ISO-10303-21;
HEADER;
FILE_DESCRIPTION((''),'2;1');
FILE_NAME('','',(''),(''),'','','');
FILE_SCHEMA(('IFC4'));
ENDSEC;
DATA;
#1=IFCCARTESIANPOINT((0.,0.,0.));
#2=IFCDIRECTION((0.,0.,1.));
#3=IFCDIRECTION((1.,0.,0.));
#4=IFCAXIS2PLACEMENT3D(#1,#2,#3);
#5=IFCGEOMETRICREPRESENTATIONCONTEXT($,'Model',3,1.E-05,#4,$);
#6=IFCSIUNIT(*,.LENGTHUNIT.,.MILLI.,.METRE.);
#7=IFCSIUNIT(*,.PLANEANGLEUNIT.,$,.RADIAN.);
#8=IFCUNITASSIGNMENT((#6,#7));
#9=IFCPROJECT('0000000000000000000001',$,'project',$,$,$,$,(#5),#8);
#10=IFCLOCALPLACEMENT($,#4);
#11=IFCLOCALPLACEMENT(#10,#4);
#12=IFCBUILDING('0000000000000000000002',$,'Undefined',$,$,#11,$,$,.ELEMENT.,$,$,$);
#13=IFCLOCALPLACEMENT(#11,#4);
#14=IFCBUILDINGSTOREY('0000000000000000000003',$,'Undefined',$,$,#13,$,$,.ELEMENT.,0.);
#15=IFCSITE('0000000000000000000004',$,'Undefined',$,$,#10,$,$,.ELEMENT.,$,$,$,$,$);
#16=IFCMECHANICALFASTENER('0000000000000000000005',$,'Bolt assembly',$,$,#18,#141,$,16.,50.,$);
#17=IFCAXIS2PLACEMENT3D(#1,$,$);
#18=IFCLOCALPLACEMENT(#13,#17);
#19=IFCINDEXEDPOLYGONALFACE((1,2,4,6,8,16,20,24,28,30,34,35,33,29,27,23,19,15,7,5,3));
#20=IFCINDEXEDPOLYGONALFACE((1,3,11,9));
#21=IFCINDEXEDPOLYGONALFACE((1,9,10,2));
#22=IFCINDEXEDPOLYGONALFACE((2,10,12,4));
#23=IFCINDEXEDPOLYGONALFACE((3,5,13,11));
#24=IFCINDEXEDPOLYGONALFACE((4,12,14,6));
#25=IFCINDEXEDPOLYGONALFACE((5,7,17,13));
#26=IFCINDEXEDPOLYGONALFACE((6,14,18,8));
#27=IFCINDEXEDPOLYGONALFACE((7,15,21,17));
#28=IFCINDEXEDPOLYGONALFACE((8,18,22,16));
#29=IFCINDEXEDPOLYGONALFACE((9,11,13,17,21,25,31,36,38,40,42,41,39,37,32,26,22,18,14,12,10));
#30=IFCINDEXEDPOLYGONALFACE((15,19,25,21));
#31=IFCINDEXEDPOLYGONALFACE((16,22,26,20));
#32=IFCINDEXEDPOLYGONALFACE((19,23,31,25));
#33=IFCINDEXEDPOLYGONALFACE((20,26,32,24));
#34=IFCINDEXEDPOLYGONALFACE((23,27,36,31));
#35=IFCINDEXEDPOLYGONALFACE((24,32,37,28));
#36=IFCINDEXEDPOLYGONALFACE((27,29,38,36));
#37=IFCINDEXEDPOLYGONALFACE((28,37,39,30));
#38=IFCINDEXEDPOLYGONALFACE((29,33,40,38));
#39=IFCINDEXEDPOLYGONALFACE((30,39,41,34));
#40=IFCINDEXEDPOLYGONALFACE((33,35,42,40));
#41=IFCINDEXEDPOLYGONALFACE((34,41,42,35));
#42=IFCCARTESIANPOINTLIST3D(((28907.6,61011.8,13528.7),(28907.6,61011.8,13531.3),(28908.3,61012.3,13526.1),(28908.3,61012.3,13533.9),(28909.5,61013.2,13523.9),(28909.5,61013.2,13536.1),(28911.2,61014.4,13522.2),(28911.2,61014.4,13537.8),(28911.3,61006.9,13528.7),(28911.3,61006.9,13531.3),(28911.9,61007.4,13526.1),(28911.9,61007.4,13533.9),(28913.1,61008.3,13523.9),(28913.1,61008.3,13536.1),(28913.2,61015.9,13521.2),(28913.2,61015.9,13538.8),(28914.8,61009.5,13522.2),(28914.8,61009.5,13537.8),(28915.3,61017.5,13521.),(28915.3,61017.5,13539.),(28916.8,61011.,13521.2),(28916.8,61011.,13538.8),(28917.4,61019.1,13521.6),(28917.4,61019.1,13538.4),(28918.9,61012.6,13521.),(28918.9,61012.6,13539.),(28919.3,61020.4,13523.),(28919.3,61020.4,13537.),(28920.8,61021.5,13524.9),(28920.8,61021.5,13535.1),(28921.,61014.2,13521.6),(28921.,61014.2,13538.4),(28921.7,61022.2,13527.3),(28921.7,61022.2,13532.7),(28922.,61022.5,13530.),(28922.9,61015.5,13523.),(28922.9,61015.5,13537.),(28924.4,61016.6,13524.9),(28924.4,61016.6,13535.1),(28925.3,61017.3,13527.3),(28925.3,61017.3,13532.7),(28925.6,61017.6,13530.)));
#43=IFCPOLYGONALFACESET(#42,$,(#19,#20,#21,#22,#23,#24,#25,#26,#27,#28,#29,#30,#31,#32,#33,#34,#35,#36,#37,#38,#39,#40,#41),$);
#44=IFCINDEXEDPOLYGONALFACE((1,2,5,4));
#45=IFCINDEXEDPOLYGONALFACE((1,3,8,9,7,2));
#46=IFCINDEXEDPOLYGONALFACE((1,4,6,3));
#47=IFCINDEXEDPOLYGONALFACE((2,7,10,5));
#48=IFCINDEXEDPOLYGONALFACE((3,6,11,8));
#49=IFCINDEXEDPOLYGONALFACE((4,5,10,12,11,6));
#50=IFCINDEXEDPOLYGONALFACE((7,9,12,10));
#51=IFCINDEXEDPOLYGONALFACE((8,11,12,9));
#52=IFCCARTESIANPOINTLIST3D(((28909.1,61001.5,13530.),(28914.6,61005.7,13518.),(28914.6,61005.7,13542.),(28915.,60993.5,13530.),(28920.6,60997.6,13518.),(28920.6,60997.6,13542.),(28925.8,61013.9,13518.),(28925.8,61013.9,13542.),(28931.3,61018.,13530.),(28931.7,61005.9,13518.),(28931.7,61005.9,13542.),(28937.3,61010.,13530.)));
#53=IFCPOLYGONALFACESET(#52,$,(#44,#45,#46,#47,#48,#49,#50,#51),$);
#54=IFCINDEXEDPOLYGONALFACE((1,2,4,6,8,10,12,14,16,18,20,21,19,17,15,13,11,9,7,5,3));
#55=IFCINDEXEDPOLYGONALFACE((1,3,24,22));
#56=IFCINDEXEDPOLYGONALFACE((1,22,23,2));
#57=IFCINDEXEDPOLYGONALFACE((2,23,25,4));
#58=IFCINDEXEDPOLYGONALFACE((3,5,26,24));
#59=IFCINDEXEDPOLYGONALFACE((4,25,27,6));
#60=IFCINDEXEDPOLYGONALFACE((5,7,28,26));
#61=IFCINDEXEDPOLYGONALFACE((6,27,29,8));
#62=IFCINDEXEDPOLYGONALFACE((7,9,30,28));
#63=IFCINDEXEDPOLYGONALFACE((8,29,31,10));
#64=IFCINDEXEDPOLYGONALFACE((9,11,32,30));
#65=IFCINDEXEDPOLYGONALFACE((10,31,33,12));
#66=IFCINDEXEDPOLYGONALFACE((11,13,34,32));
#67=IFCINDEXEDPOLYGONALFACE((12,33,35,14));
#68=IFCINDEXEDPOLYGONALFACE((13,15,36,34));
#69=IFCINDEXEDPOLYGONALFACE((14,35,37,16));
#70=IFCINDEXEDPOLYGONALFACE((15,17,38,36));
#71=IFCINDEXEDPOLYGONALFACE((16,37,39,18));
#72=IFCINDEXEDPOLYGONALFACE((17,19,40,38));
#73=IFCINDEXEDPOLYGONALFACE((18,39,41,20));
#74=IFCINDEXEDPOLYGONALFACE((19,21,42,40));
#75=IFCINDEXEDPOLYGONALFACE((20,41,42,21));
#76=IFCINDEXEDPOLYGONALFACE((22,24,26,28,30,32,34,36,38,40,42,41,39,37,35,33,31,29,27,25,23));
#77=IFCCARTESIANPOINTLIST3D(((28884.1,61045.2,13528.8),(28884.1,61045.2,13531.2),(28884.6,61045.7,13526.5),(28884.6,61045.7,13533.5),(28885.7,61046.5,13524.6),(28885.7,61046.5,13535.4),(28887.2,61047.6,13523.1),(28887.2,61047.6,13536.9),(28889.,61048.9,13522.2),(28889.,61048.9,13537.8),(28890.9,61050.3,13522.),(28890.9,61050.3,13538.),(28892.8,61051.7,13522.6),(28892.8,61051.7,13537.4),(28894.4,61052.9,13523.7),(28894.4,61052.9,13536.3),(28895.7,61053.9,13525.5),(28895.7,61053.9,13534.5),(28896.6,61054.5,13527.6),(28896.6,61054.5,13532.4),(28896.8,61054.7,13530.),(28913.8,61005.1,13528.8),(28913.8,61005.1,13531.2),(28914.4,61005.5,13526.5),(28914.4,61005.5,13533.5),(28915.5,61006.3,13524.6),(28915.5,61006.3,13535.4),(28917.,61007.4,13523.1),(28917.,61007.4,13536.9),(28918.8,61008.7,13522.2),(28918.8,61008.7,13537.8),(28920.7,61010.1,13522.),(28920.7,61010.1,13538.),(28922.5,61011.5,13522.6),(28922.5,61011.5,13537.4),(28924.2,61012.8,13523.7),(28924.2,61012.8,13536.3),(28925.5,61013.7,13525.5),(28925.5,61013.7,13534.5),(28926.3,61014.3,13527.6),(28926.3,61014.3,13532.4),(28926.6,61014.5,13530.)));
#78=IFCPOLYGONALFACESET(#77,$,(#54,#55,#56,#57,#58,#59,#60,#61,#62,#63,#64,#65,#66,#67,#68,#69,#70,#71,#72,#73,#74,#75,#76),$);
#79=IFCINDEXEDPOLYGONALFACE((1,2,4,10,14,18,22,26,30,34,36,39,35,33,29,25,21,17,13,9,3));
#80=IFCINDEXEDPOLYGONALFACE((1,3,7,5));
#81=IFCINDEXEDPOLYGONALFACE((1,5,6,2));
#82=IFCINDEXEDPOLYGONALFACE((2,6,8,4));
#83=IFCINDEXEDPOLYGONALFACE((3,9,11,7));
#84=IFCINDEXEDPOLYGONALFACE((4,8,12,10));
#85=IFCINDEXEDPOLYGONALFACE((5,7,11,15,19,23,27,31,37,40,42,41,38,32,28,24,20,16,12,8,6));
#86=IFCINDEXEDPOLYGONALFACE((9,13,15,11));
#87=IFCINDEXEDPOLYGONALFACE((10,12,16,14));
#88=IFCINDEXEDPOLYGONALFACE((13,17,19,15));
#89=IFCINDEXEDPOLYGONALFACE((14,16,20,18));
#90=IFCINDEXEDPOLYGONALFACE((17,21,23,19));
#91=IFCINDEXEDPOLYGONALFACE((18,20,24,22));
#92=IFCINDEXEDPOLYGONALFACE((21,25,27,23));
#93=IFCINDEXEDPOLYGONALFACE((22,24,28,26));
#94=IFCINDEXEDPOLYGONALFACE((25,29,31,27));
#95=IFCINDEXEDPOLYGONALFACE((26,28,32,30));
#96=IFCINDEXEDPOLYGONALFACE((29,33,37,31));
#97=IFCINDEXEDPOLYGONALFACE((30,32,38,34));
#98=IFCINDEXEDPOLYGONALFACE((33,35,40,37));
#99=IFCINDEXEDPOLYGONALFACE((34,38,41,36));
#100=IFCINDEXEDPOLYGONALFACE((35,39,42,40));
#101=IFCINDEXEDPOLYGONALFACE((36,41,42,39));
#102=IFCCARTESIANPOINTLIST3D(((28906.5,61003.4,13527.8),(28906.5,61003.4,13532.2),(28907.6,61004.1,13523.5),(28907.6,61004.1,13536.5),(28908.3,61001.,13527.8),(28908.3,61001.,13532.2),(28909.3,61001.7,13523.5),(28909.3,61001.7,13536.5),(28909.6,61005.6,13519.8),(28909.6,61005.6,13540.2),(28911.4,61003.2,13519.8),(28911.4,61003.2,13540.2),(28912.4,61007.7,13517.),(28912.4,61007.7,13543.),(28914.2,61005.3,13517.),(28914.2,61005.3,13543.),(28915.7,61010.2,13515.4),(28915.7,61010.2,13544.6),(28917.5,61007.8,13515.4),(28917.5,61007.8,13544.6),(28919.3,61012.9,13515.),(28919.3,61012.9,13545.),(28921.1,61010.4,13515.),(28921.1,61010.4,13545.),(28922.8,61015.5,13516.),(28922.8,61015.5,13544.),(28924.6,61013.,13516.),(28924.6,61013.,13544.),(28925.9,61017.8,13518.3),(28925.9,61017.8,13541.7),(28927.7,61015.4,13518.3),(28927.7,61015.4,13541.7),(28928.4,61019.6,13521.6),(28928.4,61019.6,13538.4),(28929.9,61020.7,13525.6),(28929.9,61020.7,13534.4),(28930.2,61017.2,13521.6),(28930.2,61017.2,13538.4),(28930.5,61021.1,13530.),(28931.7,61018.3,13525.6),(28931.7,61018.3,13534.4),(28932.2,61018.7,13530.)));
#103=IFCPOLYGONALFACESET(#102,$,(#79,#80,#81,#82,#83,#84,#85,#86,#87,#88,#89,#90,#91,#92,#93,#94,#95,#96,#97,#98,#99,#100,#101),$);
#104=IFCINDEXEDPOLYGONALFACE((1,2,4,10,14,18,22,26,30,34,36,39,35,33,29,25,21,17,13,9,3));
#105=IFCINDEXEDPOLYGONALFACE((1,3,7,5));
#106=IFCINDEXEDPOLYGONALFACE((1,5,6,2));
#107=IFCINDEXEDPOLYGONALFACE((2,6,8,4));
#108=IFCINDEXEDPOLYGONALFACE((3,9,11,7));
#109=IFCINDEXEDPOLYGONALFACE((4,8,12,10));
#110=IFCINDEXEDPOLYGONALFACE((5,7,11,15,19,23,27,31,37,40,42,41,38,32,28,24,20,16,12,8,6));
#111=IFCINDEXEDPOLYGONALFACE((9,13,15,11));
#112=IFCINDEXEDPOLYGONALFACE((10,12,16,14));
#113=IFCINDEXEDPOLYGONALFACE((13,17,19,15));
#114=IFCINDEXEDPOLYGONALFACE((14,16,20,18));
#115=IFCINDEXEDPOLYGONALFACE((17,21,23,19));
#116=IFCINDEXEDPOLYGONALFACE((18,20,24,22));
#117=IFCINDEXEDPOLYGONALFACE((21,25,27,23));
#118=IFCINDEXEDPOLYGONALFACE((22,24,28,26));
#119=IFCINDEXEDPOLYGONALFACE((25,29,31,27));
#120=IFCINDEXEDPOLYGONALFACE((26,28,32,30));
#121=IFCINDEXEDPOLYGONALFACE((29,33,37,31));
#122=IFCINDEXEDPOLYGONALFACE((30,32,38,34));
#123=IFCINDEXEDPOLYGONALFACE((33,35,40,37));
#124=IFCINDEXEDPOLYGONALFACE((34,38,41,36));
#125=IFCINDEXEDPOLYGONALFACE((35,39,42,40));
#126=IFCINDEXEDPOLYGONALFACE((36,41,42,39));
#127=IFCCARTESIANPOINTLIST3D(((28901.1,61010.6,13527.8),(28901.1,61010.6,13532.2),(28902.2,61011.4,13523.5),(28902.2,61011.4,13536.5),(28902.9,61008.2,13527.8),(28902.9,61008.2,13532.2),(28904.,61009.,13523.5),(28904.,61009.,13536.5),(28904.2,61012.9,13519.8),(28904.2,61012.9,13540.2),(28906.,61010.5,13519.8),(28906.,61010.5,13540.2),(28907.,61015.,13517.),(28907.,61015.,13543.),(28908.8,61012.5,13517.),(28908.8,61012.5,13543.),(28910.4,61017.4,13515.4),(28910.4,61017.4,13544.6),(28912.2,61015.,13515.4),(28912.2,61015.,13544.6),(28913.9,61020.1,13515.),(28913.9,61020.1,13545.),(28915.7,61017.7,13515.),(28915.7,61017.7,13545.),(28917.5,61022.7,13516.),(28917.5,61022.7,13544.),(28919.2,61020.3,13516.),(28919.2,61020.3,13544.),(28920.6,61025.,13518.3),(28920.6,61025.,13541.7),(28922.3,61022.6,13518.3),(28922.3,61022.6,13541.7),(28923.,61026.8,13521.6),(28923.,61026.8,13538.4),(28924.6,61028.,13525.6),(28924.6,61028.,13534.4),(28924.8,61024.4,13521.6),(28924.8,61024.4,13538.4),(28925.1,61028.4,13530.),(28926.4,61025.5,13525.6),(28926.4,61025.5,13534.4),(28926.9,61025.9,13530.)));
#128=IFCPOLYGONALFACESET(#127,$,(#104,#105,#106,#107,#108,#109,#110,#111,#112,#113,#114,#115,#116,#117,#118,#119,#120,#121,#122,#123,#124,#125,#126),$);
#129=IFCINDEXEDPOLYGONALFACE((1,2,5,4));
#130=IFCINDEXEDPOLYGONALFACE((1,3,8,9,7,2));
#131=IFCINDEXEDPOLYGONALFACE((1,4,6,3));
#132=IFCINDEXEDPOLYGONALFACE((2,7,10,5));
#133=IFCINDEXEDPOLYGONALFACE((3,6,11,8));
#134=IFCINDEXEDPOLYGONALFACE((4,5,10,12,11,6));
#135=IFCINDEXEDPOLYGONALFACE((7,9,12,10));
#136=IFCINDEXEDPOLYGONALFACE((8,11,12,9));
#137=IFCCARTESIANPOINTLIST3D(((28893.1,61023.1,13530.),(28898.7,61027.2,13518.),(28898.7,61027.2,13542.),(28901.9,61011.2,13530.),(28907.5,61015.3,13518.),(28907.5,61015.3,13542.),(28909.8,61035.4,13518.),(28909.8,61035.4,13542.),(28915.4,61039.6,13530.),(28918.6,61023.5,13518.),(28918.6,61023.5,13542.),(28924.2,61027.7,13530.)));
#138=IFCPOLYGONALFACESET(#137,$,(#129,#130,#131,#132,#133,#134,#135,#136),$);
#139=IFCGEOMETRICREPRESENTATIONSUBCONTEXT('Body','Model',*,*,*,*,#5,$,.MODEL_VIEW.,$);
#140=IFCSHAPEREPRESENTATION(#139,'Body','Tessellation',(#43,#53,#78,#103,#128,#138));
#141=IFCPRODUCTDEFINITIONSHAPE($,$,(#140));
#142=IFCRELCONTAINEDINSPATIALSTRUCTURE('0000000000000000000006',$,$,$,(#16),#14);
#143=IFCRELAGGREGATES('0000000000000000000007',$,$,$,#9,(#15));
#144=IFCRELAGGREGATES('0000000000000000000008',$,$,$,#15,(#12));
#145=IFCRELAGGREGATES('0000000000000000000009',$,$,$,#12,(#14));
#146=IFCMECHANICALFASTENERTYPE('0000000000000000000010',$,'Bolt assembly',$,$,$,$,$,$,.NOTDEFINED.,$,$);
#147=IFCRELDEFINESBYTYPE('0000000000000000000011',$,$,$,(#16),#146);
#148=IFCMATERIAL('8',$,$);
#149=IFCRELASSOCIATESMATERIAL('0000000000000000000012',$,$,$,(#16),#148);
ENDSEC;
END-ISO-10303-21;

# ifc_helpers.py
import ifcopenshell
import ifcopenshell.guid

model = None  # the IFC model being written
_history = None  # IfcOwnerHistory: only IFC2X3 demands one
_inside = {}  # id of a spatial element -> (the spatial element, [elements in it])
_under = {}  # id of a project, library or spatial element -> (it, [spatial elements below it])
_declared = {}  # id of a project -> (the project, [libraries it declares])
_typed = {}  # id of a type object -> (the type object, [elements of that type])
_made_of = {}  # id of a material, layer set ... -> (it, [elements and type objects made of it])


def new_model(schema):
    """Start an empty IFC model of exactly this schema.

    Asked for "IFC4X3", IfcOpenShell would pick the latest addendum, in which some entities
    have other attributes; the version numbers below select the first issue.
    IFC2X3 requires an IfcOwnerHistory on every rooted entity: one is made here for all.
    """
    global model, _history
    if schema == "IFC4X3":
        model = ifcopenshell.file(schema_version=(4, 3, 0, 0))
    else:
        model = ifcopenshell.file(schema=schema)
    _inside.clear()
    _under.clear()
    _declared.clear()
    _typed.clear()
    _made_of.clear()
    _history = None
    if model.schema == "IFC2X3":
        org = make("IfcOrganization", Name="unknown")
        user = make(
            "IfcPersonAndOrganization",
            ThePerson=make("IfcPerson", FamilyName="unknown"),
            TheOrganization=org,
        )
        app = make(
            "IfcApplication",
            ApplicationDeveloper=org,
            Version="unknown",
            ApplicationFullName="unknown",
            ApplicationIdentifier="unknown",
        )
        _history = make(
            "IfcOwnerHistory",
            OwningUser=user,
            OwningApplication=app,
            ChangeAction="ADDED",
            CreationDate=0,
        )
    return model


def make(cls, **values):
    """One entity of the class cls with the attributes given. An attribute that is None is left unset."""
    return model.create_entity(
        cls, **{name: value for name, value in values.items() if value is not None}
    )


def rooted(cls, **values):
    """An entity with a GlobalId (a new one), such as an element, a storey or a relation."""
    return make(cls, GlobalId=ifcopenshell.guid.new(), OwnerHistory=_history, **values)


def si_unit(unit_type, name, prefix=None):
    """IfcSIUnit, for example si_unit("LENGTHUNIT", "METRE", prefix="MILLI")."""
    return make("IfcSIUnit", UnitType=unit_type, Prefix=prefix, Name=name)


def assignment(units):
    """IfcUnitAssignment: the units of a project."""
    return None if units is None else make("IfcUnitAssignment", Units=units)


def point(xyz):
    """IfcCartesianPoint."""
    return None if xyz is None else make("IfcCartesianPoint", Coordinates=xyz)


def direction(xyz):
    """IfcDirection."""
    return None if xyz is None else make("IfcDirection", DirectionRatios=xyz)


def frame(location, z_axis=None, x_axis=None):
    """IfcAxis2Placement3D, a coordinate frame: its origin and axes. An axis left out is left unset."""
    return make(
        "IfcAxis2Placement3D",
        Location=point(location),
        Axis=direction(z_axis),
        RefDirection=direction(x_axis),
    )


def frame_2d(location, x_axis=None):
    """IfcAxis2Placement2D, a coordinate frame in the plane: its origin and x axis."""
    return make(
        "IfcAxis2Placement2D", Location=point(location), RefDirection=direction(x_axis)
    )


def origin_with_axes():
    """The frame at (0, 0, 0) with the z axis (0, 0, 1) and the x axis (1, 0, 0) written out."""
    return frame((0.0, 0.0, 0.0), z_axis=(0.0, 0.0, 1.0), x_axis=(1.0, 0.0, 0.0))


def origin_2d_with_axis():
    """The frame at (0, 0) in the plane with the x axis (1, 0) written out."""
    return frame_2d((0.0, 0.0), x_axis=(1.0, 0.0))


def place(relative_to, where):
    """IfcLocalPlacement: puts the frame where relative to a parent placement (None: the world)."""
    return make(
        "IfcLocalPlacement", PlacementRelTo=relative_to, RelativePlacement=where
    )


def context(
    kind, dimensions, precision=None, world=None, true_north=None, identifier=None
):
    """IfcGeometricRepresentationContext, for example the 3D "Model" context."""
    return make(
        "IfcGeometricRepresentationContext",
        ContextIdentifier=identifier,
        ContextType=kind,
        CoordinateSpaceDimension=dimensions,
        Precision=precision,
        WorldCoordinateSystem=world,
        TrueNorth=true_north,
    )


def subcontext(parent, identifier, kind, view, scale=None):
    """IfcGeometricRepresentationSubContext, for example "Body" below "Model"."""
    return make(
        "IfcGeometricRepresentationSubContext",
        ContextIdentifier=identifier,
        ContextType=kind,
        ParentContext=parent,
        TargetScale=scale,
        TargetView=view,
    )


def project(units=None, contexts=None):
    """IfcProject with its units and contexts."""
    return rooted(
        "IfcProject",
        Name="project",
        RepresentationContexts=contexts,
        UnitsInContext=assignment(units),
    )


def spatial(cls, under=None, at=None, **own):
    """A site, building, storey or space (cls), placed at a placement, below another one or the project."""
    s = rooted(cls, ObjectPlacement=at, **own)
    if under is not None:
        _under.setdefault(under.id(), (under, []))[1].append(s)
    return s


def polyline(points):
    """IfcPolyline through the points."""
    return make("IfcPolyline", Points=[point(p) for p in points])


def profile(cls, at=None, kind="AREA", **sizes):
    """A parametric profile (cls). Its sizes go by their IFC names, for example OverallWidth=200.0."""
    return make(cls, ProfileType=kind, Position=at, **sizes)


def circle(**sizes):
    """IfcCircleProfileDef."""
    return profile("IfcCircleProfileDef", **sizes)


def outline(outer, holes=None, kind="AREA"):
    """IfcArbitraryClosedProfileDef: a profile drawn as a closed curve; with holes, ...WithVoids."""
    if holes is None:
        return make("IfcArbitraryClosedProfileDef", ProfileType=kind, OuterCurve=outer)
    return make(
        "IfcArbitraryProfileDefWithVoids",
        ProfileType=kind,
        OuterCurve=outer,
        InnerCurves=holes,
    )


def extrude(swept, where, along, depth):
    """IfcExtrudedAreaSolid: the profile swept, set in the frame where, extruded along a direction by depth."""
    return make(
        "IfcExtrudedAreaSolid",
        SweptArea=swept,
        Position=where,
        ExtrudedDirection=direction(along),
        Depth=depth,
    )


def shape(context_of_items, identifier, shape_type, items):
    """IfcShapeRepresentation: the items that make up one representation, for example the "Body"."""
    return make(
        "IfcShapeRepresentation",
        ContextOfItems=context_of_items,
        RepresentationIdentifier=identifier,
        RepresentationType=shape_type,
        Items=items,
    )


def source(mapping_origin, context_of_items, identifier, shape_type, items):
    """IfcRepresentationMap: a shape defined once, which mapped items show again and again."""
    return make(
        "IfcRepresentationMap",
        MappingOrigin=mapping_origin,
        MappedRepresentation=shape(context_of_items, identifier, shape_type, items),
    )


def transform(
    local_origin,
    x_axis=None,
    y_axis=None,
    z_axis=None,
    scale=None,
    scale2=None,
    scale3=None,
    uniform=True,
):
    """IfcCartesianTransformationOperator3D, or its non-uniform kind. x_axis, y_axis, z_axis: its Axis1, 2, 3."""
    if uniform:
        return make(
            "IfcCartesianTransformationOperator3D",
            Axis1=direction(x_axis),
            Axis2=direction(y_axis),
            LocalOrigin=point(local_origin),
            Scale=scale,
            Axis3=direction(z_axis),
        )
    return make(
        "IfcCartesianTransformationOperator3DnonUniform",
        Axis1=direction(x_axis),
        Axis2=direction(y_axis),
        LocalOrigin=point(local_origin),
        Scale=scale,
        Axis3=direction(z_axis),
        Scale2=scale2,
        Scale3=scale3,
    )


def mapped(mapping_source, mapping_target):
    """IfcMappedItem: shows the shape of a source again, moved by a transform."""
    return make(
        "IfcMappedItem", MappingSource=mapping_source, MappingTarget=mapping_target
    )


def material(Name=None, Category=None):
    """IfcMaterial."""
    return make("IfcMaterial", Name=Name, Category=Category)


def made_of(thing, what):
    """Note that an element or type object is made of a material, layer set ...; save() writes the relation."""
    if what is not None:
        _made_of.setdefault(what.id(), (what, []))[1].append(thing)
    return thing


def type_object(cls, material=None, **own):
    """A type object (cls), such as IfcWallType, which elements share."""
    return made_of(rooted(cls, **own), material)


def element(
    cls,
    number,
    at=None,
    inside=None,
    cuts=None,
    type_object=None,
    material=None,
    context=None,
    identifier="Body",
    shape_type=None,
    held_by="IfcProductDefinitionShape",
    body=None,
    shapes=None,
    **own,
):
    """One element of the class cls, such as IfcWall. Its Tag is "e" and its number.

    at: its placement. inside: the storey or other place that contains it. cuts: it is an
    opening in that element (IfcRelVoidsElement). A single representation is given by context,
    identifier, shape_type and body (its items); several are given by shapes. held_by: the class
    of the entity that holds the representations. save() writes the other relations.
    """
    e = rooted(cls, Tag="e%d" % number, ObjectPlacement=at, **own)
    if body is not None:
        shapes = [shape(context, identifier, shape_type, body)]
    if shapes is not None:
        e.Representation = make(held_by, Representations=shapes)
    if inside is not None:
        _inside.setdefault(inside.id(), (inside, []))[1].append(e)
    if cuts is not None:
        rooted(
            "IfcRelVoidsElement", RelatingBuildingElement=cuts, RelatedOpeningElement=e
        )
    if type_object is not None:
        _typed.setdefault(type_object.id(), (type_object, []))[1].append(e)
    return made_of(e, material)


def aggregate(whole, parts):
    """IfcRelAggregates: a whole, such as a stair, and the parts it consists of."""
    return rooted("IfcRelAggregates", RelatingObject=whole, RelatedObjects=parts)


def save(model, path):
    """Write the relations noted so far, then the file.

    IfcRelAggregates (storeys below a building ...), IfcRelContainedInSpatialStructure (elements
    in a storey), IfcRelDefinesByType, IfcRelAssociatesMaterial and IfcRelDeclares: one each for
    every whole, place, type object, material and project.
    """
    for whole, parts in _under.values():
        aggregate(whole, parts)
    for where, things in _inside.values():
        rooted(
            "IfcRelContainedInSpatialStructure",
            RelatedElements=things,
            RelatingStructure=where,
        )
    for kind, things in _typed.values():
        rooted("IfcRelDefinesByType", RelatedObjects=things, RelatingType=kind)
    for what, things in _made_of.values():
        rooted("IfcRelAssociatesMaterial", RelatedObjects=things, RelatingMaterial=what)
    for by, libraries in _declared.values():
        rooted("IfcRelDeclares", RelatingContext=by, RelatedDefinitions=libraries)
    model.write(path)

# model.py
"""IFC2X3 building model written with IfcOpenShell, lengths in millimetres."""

from ifc_helpers import new_model, si_unit, frame, origin_with_axes, origin_2d_with_axis, place, context, subcontext, project, spatial, polyline, circle, outline, extrude, source, transform, mapped, material, type_object, element, save


model = new_model("IFC2X3")

# Units and contexts
model_context = context("Model", 3, precision=1e-05, world=origin_with_axes())
body_context = subcontext(model_context, "Body", "Model", "MODEL_VIEW")
ifc_project = project(units=[si_unit("LENGTHUNIT", "METRE", prefix="MILLI"), si_unit("PLANEANGLEUNIT", "RADIAN")], contexts=[model_context])

# Site, building, storey
site_placement = place(None, origin_with_axes())
site = spatial("IfcSite", under=ifc_project, at=site_placement, Name="Undefined", CompositionType="ELEMENT")
building_placement = place(site_placement, origin_with_axes())
building = spatial("IfcBuilding", under=site, at=building_placement, Name="Undefined", CompositionType="ELEMENT")
storey_placement = place(building_placement, origin_with_axes())
storey = spatial("IfcBuildingStorey", under=building, at=storey_placement, Name="Undefined", CompositionType="ELEMENT", Elevation=0.0)

# Mechanical fastener
ifc_material_1 = material(Name="8")
mechanical_fastener_type = type_object("IfcMechanicalFastenerType", Name="Bolt assembly")
shared_shape_1 = source(origin_with_axes(), body_context, "Body", "SweptSolid", [
    extrude(circle(Radius=9.0, at=origin_2d_with_axis()), frame((0.0, 2.0, 0.0), z_axis=(0.0, 1.0, 0.0), x_axis=(1.0, 0.0, 0.0)), (0.0, 0.0, 1.0), 6.1),
    extrude(outline(polyline([(13.9, 0.0), (6.9, 12.0), (-6.9, 12.0), (-13.9, 0.0), (-6.9, -12.0), (6.9, -12.0), (13.9, 0.0)])), frame((0.0, -11.0, 0.0), z_axis=(0.0, 1.0, 0.0), x_axis=(1.0, 0.0, 0.0)), (0.0, 0.0, 1.0), 10.0),
    extrude(circle(Radius=8.0, at=origin_2d_with_axis()), frame((0.0, -1.0, 0.0), z_axis=(0.0, 1.0, 0.0), x_axis=(1.0, 0.0, 0.0)), (0.0, 0.0, 1.0), 50.0),
    extrude(circle(Radius=15.0, at=origin_2d_with_axis()), frame((0.0, -1.0, 0.0), z_axis=(0.0, 1.0, 0.0), x_axis=(1.0, 0.0, 0.0)), (0.0, 0.0, 1.0), 3.0),
    extrude(circle(Radius=15.0, at=origin_2d_with_axis()), frame((0.0, 8.0, 0.0), z_axis=(0.0, 1.0, 0.0), x_axis=(1.0, 0.0, 0.0)), (0.0, 0.0, 1.0), 3.0),
    extrude(outline(polyline([(13.9, 0.0), (6.9, 12.0), (-6.9, 12.0), (-13.9, 0.0), (-6.9, -12.0), (6.9, -12.0), (13.9, 0.0)])), frame((0.0, 11.0, 0.0), z_axis=(0.0, 1.0, 0.0), x_axis=(1.0, 0.0, 0.0)), (0.0, 0.0, 1.0), 14.8),
])
mechanical_fastener_1_placement = place(storey_placement, frame((28919.6, 61010.6, 13530.0), z_axis=(0.0, 0.0, 1.0), x_axis=(0.803401, 0.595438, 0.0)))
element("IfcMechanicalFastener", 1, at=mechanical_fastener_1_placement, inside=storey, type_object=mechanical_fastener_type, material=ifc_material_1, Name="Bolt assembly", NominalDiameter=16.0, NominalLength=50.0, context=body_context, shape_type="MappedRepresentation", body=[
    mapped(shared_shape_1, transform((0.0, 0.0, 0.0))),
])

save(model, "model.ifc")
